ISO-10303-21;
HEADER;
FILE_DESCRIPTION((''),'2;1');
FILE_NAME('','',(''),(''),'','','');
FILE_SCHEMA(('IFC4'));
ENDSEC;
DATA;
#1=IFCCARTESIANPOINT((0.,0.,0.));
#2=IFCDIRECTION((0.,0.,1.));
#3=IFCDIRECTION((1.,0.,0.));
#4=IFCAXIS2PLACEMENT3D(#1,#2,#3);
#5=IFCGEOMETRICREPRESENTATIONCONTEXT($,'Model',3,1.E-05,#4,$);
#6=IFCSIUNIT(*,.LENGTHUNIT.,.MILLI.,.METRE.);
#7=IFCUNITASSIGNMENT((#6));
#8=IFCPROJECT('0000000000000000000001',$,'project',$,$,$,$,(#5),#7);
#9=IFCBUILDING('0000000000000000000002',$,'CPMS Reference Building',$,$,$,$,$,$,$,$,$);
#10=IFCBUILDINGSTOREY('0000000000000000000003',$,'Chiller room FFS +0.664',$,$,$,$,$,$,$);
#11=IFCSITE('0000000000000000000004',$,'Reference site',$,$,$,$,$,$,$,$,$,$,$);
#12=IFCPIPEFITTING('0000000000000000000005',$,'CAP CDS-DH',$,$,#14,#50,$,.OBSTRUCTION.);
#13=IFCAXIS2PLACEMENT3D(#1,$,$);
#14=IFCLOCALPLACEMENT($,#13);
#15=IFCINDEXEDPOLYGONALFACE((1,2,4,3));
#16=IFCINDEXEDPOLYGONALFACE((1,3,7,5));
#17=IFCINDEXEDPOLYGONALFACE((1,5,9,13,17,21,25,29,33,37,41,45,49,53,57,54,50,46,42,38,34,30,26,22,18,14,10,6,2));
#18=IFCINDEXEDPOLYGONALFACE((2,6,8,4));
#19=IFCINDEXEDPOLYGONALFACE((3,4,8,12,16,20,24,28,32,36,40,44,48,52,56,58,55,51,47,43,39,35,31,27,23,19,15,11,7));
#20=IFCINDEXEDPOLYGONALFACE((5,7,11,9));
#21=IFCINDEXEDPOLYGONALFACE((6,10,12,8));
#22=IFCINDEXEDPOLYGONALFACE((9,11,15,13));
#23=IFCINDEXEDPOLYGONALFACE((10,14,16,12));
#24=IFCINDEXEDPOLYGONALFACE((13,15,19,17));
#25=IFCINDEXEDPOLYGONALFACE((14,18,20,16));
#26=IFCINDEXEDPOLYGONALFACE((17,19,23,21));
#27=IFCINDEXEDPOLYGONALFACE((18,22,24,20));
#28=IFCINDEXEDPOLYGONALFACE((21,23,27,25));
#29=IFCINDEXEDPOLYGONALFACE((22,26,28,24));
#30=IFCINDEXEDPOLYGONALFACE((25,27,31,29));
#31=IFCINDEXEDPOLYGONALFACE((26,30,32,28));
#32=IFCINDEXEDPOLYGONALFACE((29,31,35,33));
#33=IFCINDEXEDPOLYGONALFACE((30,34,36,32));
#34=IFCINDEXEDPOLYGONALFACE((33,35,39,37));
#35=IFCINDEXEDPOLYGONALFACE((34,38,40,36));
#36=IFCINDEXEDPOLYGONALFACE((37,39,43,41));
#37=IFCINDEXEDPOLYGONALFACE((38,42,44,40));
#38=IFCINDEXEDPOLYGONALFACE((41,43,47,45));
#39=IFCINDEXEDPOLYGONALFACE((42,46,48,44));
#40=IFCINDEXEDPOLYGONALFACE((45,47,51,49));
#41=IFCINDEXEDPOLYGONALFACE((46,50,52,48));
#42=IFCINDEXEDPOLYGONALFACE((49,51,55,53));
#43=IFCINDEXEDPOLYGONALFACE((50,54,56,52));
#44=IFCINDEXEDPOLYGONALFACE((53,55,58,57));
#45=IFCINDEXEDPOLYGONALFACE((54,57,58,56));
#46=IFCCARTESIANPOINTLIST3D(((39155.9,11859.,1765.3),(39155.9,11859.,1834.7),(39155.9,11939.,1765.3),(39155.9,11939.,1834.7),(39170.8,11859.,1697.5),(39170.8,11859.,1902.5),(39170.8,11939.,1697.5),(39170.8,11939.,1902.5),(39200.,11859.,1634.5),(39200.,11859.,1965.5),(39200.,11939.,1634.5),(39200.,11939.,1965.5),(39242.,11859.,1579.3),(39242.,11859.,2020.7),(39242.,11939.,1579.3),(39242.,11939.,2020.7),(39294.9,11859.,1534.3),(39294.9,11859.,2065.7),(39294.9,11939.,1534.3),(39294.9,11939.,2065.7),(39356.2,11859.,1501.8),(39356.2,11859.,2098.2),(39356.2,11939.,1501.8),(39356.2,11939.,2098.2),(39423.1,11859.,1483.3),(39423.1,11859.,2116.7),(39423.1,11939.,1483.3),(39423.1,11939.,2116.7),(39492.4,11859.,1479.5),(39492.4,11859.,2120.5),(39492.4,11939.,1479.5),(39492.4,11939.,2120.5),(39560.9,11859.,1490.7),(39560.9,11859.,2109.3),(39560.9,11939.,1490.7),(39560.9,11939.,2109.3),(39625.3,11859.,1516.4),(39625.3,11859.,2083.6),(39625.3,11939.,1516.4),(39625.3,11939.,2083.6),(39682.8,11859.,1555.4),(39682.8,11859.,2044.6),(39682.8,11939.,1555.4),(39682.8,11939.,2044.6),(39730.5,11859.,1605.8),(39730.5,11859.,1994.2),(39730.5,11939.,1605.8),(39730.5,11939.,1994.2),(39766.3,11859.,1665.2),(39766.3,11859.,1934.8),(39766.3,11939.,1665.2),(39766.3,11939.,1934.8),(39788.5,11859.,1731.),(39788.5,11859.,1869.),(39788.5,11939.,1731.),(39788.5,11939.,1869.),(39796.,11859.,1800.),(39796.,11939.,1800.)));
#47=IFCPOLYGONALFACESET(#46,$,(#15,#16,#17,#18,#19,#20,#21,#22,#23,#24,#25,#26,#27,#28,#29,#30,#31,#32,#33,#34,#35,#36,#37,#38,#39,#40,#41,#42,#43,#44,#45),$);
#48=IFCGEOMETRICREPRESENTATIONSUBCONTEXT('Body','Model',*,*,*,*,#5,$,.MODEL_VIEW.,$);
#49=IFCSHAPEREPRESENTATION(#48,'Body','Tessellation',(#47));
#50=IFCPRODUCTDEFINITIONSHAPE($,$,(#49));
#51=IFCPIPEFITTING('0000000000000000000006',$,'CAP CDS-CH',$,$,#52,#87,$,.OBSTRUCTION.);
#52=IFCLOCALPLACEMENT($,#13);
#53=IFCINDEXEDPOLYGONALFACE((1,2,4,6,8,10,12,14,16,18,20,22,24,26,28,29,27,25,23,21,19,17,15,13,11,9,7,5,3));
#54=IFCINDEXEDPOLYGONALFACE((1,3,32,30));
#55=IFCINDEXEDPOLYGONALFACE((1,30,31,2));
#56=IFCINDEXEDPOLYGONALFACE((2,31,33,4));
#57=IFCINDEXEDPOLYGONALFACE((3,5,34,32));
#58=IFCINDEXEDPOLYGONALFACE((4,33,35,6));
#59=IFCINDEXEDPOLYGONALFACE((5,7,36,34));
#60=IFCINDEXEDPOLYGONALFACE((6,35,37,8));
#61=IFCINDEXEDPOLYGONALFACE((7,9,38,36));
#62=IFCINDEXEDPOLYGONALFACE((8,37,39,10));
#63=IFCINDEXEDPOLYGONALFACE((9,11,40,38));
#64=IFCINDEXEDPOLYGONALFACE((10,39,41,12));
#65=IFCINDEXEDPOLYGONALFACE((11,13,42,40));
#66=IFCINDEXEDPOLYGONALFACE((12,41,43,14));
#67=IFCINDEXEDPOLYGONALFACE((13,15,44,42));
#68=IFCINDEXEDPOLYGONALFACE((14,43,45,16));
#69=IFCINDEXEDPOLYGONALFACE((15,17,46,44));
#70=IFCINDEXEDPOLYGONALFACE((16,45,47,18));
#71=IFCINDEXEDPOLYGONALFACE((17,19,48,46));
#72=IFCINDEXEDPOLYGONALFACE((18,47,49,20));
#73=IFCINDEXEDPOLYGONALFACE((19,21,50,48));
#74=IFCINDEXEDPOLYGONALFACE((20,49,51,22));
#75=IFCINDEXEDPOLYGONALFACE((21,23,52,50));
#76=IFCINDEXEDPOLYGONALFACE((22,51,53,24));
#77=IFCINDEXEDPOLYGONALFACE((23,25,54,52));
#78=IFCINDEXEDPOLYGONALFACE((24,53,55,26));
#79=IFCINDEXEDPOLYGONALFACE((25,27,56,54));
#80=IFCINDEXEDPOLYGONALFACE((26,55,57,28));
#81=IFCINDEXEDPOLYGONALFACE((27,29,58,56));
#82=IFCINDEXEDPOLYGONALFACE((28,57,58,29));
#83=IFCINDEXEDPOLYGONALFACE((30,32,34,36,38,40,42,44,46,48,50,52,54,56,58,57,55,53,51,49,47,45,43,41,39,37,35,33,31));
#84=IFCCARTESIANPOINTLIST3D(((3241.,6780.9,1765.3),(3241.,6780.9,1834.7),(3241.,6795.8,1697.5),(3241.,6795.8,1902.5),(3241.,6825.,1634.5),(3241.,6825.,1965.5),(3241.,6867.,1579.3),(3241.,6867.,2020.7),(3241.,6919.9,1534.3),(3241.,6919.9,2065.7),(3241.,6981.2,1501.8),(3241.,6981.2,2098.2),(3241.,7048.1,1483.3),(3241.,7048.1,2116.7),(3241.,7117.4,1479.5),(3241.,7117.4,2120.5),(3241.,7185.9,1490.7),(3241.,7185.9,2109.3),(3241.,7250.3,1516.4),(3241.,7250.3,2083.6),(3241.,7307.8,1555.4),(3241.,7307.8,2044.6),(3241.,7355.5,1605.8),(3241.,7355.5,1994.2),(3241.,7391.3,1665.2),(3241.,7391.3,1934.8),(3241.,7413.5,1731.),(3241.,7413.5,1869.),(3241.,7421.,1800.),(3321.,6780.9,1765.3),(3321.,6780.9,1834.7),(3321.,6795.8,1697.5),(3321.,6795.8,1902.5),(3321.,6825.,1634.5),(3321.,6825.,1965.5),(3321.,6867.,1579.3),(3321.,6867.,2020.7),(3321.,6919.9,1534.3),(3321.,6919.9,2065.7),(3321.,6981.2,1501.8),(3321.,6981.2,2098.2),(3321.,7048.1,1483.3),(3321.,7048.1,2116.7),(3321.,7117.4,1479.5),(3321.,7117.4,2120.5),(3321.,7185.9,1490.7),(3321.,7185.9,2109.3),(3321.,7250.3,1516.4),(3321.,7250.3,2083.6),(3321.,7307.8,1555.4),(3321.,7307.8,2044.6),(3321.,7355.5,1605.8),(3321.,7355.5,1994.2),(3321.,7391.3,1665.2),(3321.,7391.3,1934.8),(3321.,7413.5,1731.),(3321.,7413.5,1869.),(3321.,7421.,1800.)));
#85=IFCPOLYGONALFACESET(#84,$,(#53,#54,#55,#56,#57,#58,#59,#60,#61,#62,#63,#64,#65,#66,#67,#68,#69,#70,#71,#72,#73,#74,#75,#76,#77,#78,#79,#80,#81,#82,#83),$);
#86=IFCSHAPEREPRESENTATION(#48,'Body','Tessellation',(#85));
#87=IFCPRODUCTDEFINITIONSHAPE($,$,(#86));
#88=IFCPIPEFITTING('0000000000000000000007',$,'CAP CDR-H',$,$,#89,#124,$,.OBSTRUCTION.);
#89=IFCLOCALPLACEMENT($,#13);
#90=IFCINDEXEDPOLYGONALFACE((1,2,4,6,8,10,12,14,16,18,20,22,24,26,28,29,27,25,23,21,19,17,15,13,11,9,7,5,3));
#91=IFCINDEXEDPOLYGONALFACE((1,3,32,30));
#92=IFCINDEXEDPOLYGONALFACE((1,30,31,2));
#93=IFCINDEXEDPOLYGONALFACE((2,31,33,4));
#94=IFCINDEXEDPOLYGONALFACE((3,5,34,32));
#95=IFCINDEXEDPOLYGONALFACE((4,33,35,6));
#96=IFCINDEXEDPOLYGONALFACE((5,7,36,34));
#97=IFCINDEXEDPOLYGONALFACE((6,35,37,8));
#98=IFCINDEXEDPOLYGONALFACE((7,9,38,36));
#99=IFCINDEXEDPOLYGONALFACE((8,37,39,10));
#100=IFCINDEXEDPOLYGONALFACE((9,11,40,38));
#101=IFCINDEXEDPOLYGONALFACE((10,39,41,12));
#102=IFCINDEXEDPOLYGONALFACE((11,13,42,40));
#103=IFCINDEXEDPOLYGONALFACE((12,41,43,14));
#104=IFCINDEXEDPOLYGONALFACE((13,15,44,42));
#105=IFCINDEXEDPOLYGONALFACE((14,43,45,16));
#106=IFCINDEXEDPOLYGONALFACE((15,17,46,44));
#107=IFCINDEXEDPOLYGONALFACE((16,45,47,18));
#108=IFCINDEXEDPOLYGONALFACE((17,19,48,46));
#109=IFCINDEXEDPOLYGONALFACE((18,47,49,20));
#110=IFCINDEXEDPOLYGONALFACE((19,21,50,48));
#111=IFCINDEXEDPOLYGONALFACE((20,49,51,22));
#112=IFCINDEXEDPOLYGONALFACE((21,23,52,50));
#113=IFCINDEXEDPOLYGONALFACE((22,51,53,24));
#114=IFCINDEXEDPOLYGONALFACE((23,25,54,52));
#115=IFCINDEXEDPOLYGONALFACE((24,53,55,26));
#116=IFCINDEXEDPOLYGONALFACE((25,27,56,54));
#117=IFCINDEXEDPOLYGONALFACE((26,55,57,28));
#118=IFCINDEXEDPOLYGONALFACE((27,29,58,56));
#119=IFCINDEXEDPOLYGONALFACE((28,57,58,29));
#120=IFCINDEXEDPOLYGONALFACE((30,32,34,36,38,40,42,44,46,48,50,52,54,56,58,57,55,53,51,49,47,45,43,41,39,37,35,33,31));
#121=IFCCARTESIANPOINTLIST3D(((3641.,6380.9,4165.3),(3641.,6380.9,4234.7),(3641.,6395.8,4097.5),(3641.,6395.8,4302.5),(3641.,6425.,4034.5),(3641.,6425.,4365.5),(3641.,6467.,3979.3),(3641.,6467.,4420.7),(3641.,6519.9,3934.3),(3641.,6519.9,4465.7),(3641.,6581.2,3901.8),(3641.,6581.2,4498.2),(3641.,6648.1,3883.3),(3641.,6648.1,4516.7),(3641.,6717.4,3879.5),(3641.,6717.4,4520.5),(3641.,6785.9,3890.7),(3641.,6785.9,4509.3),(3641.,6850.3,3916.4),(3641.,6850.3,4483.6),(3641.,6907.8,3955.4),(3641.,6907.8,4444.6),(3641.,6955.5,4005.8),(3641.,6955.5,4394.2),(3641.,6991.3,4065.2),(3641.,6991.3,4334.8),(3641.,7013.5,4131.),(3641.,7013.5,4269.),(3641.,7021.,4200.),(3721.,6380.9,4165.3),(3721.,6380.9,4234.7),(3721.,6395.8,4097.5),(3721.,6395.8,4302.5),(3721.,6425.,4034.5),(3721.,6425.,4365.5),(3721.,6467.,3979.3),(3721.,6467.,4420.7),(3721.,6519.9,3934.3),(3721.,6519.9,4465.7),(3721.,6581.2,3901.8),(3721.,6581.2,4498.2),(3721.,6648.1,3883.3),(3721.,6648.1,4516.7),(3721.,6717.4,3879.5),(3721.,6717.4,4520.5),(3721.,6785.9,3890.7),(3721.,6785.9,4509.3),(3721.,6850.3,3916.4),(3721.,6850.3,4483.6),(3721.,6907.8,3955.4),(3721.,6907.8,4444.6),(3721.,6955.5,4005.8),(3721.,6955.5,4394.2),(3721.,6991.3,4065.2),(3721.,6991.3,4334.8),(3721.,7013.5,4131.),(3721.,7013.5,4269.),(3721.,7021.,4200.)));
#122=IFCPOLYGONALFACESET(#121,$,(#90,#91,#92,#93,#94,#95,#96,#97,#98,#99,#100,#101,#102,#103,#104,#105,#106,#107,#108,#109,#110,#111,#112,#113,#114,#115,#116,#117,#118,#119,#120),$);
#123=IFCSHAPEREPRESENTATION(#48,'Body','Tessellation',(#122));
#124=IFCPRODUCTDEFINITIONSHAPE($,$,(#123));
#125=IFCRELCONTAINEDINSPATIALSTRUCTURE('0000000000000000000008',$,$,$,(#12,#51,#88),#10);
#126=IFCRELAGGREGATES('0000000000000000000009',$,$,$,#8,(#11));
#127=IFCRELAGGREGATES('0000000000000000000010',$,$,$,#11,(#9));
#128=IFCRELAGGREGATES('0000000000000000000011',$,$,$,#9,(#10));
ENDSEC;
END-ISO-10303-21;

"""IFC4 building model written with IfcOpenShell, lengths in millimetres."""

from ifc_helpers import new_model, si_unit, frame, origin_with_axes, origin_2d, place, context, subcontext, project, spatial, circle_curve, outline, extrude, element, save


model = new_model("IFC4")

# Units and contexts
model_context = context("Model", 3, precision=1e-05, world=origin_with_axes())
body_context = subcontext(model_context, "Body", "Model", "MODEL_VIEW")
ifc_project = project(units=[si_unit("LENGTHUNIT", "METRE", prefix="MILLI")], contexts=[model_context])

# Site, building, storey
site = spatial("IfcSite", under=ifc_project, Name="Reference site")
building = spatial("IfcBuilding", under=site, Name="CPMS Reference Building")
storey = spatial("IfcBuildingStorey", under=building, Name="Chiller room FFS +0.664")

# Pipe fittings
pipe_fitting_1_placement = place(None, origin_with_axes())
element("IfcPipeFitting", 1, at=pipe_fitting_1_placement, inside=storey, Name="CAP CDS-DH", PredefinedType="OBSTRUCTION", context=body_context, shape_type="SweptSolid", body=[
    extrude(outline(circle_curve(origin_2d(), 321.0)), frame((39475.0, 11859.0, 1800.0), z_axis=(0.0, 1.0, 0.0), x_axis=(1.0, 0.0, 0.0)), (0.0, 0.0, 1.0), 80.0),
])
pipe_fitting_2_placement = place(None, origin_with_axes())
element("IfcPipeFitting", 2, at=pipe_fitting_2_placement, inside=storey, Name="CAP CDS-CH", PredefinedType="OBSTRUCTION", context=body_context, shape_type="SweptSolid", body=[
    extrude(outline(circle_curve(origin_2d(), 321.0)), frame((3321.0, 7100.0, 1800.0), z_axis=(-1.0, 0.0, 0.0), x_axis=(0.0, 1.0, 0.0)), (0.0, 0.0, 1.0), 80.0),
])
pipe_fitting_3_placement = place(None, origin_with_axes())
element("IfcPipeFitting", 3, at=pipe_fitting_3_placement, inside=storey, Name="CAP CDR-H", PredefinedType="OBSTRUCTION", context=body_context, shape_type="SweptSolid", body=[
    extrude(outline(circle_curve(origin_2d(), 321.0)), frame((3641.0, 6700.0, 4200.0), z_axis=(1.0, 0.0, 0.0), x_axis=(0.0, 1.0, 0.0)), (0.0, 0.0, 1.0), 80.0),
])

save(model, "model.ifc")
